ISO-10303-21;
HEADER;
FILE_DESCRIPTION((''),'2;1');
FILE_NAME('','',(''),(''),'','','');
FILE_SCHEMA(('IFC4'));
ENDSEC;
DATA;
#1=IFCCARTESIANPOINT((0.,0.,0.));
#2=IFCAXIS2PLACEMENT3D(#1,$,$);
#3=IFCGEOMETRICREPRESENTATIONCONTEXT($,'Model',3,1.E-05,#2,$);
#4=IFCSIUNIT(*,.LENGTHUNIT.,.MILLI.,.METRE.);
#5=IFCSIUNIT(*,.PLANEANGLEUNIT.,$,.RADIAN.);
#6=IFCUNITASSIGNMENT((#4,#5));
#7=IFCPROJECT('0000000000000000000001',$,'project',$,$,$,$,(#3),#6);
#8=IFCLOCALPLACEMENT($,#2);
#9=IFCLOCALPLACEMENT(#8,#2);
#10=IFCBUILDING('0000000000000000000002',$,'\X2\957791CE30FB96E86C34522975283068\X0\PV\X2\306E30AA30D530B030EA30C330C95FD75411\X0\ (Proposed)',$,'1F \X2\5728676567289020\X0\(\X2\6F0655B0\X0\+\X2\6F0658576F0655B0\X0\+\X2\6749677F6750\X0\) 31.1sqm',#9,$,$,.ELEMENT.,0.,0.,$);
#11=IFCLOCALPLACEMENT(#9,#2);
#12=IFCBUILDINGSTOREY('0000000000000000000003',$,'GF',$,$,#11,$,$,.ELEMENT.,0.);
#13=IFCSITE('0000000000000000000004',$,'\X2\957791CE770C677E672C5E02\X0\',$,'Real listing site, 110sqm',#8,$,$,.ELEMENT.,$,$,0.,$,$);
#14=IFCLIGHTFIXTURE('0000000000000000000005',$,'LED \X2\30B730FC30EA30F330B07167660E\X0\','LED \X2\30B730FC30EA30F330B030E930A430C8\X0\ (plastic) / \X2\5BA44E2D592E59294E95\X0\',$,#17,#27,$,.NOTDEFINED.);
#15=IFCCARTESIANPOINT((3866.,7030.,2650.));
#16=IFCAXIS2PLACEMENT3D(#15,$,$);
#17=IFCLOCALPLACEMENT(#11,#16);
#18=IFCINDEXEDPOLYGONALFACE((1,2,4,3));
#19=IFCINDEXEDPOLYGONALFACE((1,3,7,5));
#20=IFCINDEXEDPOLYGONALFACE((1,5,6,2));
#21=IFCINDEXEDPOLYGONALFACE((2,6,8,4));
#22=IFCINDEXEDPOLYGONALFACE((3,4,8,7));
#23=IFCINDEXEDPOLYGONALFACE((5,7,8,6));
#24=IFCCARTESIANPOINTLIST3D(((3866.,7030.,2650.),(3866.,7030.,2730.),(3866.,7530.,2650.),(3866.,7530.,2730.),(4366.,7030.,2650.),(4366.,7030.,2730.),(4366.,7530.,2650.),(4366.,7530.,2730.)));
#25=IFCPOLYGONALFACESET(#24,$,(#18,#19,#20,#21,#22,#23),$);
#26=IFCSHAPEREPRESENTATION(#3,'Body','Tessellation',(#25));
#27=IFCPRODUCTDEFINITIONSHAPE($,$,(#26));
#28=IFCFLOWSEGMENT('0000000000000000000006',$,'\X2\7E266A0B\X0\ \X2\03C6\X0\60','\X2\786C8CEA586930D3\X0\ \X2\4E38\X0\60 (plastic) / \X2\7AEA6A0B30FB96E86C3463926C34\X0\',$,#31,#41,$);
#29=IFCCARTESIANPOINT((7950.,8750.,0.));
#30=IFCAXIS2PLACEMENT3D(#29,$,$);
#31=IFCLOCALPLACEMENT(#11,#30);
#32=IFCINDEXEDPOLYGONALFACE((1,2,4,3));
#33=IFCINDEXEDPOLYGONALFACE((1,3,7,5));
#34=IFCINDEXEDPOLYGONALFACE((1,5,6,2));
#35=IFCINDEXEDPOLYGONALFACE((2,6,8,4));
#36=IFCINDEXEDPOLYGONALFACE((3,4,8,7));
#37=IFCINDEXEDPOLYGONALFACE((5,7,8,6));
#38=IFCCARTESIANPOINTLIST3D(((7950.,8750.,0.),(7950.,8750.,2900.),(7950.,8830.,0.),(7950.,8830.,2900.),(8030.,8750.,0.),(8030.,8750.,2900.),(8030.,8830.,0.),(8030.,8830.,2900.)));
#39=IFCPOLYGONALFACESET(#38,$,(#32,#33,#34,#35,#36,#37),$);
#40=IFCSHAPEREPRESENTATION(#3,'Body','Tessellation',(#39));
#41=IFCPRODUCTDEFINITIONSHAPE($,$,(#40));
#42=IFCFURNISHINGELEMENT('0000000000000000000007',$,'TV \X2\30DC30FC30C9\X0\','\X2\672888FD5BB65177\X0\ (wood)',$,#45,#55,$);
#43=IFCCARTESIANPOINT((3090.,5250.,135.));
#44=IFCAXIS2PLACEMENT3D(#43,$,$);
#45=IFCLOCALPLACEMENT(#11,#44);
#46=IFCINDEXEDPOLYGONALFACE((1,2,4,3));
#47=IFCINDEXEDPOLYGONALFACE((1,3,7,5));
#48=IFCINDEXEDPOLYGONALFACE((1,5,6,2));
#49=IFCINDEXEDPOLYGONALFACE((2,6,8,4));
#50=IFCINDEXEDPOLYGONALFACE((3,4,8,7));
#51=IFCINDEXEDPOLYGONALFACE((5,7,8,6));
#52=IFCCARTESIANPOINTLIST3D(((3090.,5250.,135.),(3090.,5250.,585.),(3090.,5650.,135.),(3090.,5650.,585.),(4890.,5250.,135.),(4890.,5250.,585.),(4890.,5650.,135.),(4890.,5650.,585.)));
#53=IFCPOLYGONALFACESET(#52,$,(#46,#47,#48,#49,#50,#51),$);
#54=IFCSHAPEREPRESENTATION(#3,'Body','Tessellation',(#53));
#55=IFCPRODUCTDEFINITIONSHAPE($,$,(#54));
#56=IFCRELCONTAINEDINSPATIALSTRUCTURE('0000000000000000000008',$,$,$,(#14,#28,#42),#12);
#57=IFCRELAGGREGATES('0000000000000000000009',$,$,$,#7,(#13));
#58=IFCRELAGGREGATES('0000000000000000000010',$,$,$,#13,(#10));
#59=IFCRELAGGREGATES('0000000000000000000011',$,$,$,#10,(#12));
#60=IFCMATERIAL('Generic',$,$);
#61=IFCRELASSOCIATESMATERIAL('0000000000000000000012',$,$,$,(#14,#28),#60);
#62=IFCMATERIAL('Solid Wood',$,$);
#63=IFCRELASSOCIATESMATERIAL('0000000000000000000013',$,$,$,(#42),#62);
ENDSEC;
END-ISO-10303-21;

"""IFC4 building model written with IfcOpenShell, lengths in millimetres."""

from ifc_helpers import new_model, si_unit, frame, frame_2d, origin, place, context, project, spatial, rectangle, extrude, material, element, save


model = new_model("IFC4")

# Units and contexts
model_context = context("Model", 3, precision=1e-05, world=origin())
ifc_project = project(units=[si_unit("LENGTHUNIT", "METRE", prefix="MILLI"), si_unit("PLANEANGLEUNIT", "RADIAN")], contexts=[model_context])

# Site, building, storey
site_placement = place(None, origin())
site = spatial("IfcSite", under=ifc_project, at=site_placement, Name="長野県松本市", ObjectType="Real listing site, 110sqm", CompositionType="ELEMENT", RefElevation=0.0)
building_placement = place(site_placement, origin())
building = spatial("IfcBuilding", under=site, at=building_placement, Name="長野・雨水利用とPVのオフグリッド志向 (Proposed)", ObjectType="1F 在来木造(漆喰+漆塗漆喰+杉板材) 31.1sqm", CompositionType="ELEMENT", ElevationOfRefHeight=0.0, ElevationOfTerrain=0.0)
storey_placement = place(building_placement, origin())
storey = spatial("IfcBuildingStorey", under=building, at=storey_placement, Name="GF", CompositionType="ELEMENT", Elevation=0.0)

# Shared definitions
ifc_material_1 = material(Name="Solid Wood")

# Shared definitions
ifc_material_2 = material(Name="Generic")

# Light fixture
light_fixture_1_placement = place(storey_placement, frame((3866.0, 7030.0, 2650.0)))
element("IfcLightFixture", 1, at=light_fixture_1_placement, inside=storey, material=ifc_material_2, Name="LED シーリング照明", Description="LED シーリングライト (plastic) / 室中央天井", PredefinedType="NOTDEFINED", context=model_context, shape_type="SweptSolid", body=[
    extrude(rectangle(XDim=500.0, YDim=500.0, at=frame_2d((250.0, 250.0))), frame((3866.0, 7030.0, 2650.0)), (0.0, 0.0, 1.0), 80.0),
])

# Flow segment
flow_segment_placement = place(storey_placement, frame((7950.0, 8750.0, 0.0)))
element("IfcFlowSegment", 2, at=flow_segment_placement, inside=storey, material=ifc_material_2, Name="縦樋 φ60", Description="硬質塩ビ 丸60 (plastic) / 竪樋・雨水排水", context=model_context, shape_type="SweptSolid", body=[
    extrude(rectangle(XDim=80.0, YDim=80.0, at=frame_2d((40.0, 40.0))), frame((7950.0, 8750.0, 0.0)), (0.0, 0.0, 1.0), 2900.0),
])

# Furnishing element
furnishing_placement = place(storey_placement, frame((3090.0, 5250.0, 135.0)))
element("IfcFurnishingElement", 3, at=furnishing_placement, inside=storey, material=ifc_material_1, Name="TV ボード", Description="木製家具 (wood)", context=model_context, shape_type="SweptSolid", body=[
    extrude(rectangle(XDim=1800.0, YDim=400.0, at=frame_2d((900.0, 200.0))), frame((3090.0, 5250.0, 135.0)), (0.0, 0.0, 1.0), 450.0),
])

save(model, "model.ifc")
